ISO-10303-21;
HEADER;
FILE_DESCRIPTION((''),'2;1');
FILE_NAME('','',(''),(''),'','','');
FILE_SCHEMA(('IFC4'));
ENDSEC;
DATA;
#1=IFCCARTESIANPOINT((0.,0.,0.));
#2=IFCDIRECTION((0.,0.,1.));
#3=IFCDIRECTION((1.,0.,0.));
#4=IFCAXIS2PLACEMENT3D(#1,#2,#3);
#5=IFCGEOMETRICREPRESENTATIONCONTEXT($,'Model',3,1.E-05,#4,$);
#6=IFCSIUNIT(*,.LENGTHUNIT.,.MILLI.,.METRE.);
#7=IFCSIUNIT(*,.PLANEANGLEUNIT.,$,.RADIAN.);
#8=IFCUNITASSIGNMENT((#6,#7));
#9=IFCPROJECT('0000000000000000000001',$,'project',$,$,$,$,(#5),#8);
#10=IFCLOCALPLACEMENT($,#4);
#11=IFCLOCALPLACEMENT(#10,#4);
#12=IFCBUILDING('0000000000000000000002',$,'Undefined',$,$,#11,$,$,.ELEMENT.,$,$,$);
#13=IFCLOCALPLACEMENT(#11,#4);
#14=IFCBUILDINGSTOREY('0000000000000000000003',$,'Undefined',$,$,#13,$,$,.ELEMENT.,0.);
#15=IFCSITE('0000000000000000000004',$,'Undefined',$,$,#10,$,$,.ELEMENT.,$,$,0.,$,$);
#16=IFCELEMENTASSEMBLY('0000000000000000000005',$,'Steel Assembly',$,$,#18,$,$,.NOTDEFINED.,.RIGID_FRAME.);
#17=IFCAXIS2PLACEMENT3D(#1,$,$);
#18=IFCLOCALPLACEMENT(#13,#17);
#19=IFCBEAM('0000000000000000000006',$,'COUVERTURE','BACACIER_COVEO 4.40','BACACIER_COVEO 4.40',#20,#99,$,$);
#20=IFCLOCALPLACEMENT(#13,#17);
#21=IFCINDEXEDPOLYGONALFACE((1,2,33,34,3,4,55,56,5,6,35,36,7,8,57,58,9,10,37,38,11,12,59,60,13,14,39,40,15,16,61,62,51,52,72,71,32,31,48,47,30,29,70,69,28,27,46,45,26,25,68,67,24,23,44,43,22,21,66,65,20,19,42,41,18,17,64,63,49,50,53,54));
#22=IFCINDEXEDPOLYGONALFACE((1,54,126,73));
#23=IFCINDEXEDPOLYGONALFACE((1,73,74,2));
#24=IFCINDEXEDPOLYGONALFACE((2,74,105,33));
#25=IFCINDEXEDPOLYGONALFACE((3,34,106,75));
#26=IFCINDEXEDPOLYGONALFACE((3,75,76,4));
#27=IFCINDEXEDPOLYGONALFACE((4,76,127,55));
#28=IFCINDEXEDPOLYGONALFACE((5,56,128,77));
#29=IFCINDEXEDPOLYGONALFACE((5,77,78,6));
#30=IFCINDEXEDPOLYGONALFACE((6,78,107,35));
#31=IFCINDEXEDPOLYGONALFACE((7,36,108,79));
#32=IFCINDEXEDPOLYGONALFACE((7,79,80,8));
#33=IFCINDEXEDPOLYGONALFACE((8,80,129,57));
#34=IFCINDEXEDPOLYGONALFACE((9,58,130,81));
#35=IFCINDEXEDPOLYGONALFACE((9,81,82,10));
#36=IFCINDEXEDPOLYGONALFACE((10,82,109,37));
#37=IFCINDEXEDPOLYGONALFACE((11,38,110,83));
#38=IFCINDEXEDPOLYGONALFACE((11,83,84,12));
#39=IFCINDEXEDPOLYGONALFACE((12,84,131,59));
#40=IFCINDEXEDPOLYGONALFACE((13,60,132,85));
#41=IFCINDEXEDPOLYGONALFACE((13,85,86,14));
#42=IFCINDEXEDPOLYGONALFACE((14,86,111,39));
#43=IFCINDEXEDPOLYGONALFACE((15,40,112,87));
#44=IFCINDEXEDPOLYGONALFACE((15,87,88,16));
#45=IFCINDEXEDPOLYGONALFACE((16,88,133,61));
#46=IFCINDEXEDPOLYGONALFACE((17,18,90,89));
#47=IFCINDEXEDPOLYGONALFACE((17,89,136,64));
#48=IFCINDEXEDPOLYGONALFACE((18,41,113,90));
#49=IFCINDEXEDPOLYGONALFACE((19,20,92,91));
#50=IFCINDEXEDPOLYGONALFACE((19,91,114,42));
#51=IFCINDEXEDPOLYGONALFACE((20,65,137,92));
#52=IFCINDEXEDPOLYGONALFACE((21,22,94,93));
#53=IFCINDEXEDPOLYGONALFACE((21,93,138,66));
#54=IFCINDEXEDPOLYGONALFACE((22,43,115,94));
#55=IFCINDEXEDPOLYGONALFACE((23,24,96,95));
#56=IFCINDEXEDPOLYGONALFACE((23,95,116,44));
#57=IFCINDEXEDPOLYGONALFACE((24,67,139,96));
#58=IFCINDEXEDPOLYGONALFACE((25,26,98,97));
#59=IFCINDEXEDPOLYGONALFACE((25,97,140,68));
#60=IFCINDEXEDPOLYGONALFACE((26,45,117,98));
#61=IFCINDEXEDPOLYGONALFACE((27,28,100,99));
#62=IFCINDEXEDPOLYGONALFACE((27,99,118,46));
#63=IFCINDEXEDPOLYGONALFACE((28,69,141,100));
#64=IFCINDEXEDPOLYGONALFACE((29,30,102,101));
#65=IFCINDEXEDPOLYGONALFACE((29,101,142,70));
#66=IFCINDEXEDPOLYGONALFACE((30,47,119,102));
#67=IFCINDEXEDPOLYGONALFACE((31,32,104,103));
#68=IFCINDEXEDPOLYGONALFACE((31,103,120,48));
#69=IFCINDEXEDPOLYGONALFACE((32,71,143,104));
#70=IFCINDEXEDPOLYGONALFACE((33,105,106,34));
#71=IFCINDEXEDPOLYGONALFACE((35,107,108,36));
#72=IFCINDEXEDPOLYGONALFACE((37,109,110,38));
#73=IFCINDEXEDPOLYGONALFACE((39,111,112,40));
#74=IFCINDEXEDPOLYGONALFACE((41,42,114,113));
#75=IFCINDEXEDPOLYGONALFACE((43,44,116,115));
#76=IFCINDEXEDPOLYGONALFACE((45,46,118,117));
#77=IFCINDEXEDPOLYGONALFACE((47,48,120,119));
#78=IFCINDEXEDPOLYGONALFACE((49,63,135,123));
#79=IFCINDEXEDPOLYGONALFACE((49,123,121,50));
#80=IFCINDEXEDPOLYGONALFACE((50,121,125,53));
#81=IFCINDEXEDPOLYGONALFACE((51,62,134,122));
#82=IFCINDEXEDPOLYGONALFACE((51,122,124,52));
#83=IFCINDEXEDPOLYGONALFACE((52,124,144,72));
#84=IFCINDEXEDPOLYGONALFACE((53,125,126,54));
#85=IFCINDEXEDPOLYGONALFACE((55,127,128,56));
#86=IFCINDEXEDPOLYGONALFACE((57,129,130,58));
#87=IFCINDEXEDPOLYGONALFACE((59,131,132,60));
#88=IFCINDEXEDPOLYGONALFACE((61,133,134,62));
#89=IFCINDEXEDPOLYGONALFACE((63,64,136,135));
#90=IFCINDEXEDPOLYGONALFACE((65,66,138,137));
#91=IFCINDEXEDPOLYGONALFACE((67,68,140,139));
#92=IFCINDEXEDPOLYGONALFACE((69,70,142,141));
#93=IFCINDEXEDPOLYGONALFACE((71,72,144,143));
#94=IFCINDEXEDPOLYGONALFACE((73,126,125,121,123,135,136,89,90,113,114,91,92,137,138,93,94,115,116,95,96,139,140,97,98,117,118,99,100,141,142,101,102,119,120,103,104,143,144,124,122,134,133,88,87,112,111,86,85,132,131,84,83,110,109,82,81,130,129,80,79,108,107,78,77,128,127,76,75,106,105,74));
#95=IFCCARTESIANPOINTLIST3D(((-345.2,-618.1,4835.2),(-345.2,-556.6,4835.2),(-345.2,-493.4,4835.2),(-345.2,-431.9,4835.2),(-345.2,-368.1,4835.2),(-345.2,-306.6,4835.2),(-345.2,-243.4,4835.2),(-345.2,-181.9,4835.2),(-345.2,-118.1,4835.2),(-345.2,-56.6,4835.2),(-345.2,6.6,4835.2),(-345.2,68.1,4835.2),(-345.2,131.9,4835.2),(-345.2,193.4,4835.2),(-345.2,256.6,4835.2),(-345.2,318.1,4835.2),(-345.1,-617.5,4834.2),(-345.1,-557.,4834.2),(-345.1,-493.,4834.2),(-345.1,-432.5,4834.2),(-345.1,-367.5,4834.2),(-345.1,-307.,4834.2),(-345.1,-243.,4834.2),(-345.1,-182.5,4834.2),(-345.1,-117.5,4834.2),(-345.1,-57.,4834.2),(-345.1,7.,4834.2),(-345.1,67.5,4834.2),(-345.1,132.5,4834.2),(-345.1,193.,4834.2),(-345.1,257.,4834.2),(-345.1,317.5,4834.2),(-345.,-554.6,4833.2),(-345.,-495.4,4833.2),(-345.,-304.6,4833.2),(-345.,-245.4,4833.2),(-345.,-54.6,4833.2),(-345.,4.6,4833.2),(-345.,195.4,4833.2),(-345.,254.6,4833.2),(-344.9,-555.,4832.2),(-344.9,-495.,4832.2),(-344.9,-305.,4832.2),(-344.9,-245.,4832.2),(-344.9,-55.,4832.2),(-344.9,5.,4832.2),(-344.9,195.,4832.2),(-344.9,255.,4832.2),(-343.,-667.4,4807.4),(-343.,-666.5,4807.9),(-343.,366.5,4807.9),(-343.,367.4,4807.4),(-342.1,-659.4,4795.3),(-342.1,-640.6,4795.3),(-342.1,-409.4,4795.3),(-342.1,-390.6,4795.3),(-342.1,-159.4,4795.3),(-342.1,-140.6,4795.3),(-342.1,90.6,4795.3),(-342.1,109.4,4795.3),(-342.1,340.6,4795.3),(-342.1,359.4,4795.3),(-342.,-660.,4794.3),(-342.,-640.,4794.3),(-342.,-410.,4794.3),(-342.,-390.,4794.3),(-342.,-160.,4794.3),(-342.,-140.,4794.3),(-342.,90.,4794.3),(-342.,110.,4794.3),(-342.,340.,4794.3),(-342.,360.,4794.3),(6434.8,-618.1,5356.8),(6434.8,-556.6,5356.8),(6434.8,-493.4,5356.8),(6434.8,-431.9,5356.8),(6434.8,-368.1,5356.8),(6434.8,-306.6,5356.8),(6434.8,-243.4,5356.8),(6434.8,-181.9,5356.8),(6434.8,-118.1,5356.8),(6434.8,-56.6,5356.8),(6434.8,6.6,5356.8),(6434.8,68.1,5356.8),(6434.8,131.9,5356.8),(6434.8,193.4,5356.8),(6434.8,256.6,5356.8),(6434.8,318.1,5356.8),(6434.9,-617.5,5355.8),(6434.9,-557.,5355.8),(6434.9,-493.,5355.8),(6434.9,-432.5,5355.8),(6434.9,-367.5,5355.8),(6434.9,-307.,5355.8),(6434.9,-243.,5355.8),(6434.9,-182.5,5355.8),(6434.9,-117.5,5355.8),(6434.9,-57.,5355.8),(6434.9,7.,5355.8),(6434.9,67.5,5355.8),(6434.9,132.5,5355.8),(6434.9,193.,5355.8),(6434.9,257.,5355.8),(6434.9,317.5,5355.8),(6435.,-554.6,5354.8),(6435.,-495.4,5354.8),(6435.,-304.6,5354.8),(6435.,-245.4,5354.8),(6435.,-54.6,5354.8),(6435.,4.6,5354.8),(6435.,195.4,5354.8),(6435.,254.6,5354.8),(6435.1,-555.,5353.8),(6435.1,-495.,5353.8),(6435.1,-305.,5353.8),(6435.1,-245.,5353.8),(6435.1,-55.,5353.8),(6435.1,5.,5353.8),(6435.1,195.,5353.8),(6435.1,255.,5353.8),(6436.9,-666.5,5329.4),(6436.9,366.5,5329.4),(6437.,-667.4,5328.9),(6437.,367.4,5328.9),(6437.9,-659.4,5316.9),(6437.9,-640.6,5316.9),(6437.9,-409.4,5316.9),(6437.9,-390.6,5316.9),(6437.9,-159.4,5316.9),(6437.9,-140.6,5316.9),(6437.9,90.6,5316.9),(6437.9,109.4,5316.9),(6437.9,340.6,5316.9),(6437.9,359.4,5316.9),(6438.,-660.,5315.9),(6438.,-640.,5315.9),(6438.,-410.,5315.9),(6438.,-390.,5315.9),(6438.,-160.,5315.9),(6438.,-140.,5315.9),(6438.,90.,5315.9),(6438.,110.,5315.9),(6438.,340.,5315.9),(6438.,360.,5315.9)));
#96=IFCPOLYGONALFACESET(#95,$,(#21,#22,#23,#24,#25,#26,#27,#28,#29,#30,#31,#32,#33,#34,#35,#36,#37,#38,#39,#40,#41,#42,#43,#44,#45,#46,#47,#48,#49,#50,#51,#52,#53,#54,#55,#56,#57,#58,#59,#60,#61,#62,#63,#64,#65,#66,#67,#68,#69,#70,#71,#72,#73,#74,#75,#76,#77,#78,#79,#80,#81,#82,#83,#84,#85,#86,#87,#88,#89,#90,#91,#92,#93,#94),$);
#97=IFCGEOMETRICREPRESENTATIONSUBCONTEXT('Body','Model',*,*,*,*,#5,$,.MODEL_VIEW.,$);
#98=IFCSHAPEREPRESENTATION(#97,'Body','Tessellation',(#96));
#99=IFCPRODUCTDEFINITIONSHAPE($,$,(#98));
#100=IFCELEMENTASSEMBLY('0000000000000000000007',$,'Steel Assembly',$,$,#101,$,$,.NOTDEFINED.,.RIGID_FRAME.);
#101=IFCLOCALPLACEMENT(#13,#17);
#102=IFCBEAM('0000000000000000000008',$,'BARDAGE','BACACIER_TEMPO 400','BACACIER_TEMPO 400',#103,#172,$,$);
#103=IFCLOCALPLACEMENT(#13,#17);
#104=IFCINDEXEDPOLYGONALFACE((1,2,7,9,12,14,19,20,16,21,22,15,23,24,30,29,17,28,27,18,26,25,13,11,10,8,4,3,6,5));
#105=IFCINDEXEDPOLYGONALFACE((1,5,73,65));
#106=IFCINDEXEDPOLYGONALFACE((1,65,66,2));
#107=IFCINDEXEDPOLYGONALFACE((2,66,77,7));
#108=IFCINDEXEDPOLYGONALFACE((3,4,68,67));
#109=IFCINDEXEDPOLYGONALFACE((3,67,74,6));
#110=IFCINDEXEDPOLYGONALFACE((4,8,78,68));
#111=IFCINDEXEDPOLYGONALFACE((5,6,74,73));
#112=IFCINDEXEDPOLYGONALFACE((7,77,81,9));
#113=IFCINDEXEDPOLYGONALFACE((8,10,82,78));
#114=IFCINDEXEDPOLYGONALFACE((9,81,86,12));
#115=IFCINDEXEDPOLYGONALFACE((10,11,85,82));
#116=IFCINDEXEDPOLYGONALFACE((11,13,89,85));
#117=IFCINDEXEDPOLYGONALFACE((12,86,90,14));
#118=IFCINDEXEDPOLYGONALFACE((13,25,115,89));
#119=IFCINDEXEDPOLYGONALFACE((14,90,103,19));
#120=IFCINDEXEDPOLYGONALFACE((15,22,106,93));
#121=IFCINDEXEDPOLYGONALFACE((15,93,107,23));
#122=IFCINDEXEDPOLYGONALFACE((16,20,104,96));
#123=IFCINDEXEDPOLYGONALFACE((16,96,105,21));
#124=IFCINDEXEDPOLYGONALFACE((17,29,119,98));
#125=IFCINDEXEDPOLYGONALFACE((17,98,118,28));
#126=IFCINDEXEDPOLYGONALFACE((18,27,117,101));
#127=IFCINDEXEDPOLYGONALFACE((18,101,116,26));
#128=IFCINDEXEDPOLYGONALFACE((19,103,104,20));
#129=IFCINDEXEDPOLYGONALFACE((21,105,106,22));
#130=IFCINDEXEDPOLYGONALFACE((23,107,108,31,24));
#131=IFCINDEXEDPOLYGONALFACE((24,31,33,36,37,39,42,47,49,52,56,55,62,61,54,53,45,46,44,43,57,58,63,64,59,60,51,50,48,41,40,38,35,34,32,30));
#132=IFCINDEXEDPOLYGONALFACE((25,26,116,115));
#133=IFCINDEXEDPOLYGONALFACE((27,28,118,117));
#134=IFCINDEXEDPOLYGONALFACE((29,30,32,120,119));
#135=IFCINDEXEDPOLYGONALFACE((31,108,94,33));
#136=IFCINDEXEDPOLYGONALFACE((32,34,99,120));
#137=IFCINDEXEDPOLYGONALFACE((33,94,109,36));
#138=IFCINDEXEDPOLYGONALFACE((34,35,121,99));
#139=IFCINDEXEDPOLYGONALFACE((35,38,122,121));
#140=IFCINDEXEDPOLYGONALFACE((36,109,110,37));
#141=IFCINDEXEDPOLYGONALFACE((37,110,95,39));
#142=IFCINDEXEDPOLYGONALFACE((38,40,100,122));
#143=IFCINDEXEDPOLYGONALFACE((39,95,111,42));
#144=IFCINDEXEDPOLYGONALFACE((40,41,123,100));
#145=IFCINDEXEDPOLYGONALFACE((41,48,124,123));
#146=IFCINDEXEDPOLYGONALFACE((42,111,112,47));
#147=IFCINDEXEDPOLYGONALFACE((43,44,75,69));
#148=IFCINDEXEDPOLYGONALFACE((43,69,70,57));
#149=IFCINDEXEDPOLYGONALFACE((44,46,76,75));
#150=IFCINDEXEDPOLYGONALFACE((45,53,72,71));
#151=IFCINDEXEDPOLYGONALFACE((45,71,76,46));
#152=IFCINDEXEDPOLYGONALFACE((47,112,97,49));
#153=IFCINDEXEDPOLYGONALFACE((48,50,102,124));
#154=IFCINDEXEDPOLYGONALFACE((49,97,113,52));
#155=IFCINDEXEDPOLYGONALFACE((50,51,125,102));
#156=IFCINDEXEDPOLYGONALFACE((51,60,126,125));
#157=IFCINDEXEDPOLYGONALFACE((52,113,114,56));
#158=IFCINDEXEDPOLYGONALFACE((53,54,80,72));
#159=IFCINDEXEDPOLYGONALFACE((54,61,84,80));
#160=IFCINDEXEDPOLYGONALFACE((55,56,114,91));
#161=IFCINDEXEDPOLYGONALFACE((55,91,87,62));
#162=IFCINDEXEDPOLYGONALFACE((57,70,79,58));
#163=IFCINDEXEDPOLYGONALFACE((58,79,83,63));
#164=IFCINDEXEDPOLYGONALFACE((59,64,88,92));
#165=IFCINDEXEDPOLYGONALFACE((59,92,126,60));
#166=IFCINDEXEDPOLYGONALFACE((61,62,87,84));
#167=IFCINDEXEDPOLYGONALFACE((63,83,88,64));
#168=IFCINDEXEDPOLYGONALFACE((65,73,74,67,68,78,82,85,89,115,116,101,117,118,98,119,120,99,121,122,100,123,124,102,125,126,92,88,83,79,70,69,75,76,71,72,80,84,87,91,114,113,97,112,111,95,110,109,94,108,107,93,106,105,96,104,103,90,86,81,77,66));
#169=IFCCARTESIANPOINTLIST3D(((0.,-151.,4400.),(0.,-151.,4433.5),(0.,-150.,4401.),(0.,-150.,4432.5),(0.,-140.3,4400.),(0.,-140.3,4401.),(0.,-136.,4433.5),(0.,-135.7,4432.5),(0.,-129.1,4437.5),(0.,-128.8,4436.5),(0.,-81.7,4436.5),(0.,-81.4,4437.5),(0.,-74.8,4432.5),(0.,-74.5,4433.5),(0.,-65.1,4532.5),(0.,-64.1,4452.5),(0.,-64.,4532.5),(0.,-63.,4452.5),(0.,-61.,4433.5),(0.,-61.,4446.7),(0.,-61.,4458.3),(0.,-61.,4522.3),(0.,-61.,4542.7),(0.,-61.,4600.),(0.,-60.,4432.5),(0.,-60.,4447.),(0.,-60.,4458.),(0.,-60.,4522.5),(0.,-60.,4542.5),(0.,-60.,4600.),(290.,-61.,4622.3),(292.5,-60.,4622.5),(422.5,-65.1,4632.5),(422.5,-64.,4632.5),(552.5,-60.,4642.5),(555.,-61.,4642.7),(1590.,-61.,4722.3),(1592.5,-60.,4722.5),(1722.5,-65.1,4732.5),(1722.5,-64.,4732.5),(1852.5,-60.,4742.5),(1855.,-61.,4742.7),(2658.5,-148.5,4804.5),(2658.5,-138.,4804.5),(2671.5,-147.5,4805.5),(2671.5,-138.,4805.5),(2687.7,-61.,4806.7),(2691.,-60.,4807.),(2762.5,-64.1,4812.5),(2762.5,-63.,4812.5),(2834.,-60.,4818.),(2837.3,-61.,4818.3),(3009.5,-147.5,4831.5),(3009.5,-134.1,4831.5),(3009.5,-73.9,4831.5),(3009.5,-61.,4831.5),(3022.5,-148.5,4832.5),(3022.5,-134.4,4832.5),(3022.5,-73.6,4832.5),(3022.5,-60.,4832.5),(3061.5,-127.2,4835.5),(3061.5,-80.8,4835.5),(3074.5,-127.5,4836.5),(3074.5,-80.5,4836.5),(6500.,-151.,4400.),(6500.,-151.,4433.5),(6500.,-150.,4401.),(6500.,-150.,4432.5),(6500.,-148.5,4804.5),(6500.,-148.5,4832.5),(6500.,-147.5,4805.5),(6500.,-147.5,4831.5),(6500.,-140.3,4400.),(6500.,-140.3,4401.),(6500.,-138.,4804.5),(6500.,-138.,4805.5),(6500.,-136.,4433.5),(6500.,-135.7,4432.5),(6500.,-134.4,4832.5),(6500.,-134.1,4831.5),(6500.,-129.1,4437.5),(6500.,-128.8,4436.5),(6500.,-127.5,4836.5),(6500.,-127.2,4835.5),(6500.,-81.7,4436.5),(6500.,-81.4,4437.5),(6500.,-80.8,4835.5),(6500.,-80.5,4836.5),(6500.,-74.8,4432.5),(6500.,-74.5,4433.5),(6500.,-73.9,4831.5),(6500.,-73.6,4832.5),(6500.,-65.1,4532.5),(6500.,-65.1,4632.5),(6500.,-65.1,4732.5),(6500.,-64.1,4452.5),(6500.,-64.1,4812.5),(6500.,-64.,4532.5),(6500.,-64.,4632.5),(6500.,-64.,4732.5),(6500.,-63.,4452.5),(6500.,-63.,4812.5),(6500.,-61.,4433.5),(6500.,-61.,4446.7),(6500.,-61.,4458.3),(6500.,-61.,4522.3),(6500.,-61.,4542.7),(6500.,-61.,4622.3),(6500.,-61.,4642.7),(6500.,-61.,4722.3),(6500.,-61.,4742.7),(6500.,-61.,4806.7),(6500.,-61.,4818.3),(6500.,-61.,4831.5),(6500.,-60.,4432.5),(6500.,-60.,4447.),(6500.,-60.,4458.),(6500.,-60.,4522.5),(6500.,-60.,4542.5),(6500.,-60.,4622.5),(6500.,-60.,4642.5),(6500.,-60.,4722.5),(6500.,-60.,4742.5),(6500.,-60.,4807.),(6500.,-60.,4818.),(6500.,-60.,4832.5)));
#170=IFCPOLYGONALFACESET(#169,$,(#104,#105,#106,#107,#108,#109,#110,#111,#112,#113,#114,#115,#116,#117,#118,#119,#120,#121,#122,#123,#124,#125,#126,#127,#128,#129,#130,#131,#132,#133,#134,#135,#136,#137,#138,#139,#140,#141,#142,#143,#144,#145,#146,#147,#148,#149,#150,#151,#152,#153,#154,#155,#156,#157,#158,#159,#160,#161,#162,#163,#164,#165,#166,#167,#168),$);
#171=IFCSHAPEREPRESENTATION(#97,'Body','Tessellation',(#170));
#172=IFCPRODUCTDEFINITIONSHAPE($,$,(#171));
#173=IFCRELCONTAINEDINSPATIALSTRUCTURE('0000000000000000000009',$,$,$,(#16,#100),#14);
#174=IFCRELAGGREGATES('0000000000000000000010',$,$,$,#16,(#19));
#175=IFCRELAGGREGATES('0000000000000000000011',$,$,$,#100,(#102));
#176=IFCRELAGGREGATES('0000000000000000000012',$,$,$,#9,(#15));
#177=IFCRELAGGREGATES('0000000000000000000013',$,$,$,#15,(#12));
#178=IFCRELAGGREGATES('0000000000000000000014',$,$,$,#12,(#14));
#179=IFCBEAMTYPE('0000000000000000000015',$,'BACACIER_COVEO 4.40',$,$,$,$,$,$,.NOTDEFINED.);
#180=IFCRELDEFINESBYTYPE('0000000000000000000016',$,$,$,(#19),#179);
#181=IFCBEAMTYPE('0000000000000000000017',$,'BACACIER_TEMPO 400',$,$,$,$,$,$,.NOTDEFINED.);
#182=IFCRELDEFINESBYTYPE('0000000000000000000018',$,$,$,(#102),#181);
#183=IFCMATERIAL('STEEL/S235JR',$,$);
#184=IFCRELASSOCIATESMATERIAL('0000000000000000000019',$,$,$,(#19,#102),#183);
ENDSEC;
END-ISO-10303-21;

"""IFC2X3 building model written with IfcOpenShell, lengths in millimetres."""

from ifc_helpers import new_model, si_unit, frame, origin_with_axes, place, context, subcontext, project, spatial, polyline, outline, extrude, clip, halfspace, material, type_object, element, aggregate, save


model = new_model("IFC2X3")

# Units and contexts
model_context = context("Model", 3, precision=1e-05, world=origin_with_axes())
body_context = subcontext(model_context, "Body", "Model", "MODEL_VIEW")
ifc_project = project(units=[si_unit("LENGTHUNIT", "METRE", prefix="MILLI"), si_unit("PLANEANGLEUNIT", "RADIAN")], contexts=[model_context])

# Site, building, storey
site_placement = place(None, origin_with_axes())
site = spatial("IfcSite", under=ifc_project, at=site_placement, Name="Undefined", CompositionType="ELEMENT", RefElevation=0.0)
building_placement = place(site_placement, origin_with_axes())
building = spatial("IfcBuilding", under=site, at=building_placement, Name="Undefined", CompositionType="ELEMENT")
storey_placement = place(building_placement, origin_with_axes())
storey = spatial("IfcBuildingStorey", under=building, at=storey_placement, Name="Undefined", CompositionType="ELEMENT", Elevation=0.0)

# Element assemblies, beams
assembly_1_placement = place(storey_placement, origin_with_axes())
assembly_1 = element("IfcElementAssembly", 1, at=assembly_1_placement, inside=storey, Name="Steel Assembly", AssemblyPlace="NOTDEFINED", PredefinedType="RIGID_FRAME")
ifc_material_1 = material(Name="STEEL/S235JR")
beam_type_1 = type_object("IfcBeamType", Name="BACACIER_COVEO 4.40", PredefinedType="NOTDEFINED")
beam_1_placement = place(assembly_1_placement, frame((6436.4, -150.0, 5336.3), z_axis=(0.076696, 0.0, -0.997054), x_axis=(-0.997054, 0.0, -0.076696)))
beam_1 = element("IfcBeam", 2, at=beam_1_placement, type_object=beam_type_1, material=ifc_material_1, Name="COUVERTURE", Description="BACACIER_COVEO 4.40", ObjectType="BACACIER_COVEO 4.40", context=body_context, shape_type="SweptSolid", body=[
    extrude(outline(polyline([(509.4, 19.5), (490.6, 19.5), (468.1, -20.5), (406.6, -20.5), (404.6, -18.5), (345.4, -18.5), (343.4, -20.5), (281.9, -20.5), (259.4, 19.5), (240.6, 19.5), (218.1, -20.5), (156.6, -20.5), (154.6, -18.5), (95.4, -18.5), (93.4, -20.5), (31.9, -20.5), (9.4, 19.5), (-9.4, 19.5), (-31.9, -20.5), (-93.4, -20.5), (-95.4, -18.5), (-154.6, -18.5), (-156.6, -20.5), (-218.1, -20.5), (-240.6, 19.5), (-259.4, 19.5), (-281.9, -20.5), (-343.4, -20.5), (-345.4, -18.5), (-404.6, -18.5), (-406.6, -20.5), (-468.1, -20.5), (-490.6, 19.5), (-509.4, 19.5), (-516.5, 6.9), (-517.4, 7.4), (-510.0, 20.5), (-490.0, 20.5), (-467.5, -19.5), (-407.0, -19.5), (-405.0, -17.5), (-345.0, -17.5), (-343.0, -19.5), (-282.5, -19.5), (-260.0, 20.5), (-240.0, 20.5), (-217.5, -19.5), (-157.0, -19.5), (-155.0, -17.5), (-95.0, -17.5), (-93.0, -19.5), (-32.5, -19.5), (-10.0, 20.5), (10.0, 20.5), (32.5, -19.5), (93.0, -19.5), (95.0, -17.5), (155.0, -17.5), (157.0, -19.5), (217.5, -19.5), (240.0, 20.5), (260.0, 20.5), (282.5, -19.5), (343.0, -19.5), (345.0, -17.5), (405.0, -17.5), (407.0, -19.5), (467.5, -19.5), (490.0, 20.5), (510.0, 20.5), (517.4, 7.4), (516.5, 6.9), (509.4, 19.5)])), frame((6800.0, 0.0, 0.0), z_axis=(-1.0, 0.0, 0.0), x_axis=(0.0, -1.0, 0.0)), (0.0, 0.0, 1.0), 6800.0),
])
aggregate(assembly_1, [beam_1])
beam_type_2 = type_object("IfcBeamType", Name="BACACIER_TEMPO 400", PredefinedType="NOTDEFINED")
assembly_2_placement = place(storey_placement, origin_with_axes())
assembly_2 = element("IfcElementAssembly", 3, at=assembly_2_placement, inside=storey, Name="Steel Assembly", AssemblyPlace="NOTDEFINED", PredefinedType="RIGID_FRAME")
beam_2_placement = place(assembly_2_placement, frame((6500.0, -105.5, 4618.2), z_axis=(0.0, -1.0, 0.0), x_axis=(-1.0, 0.0, 0.0)))
beam_2 = element("IfcBeam", 4, at=beam_2_placement, type_object=beam_type_2, material=ifc_material_1, Name="BARDAGE", Description="BACACIER_TEMPO 400", ObjectType="BACACIER_TEMPO 400", context=body_context, shape_type="Clipping", body=[
    clip(extrude(outline(polyline([(218.2, -25.0), (214.2, -31.9), (214.2, -45.5), (199.8, -45.5), (194.2, -42.5), (188.8, -45.5), (124.2, -45.5), (114.2, -41.5), (104.2, -45.5), (24.2, -45.5), (14.2, -41.5), (4.2, -45.5), (-75.8, -45.5), (-85.8, -41.5), (-95.8, -45.5), (-160.2, -45.5), (-165.8, -42.5), (-171.2, -45.5), (-185.8, -45.5), (-185.8, -30.7), (-181.8, -23.8), (-181.8, 23.3), (-185.8, 30.2), (-185.8, 44.5), (-217.2, 44.5), (-217.2, 34.8), (-218.2, 34.8), (-218.2, 45.5), (-184.8, 45.5), (-184.8, 30.5), (-180.8, 23.6), (-180.8, -24.1), (-184.8, -31.0), (-184.8, -44.5), (-171.5, -44.5), (-165.8, -41.4), (-160.0, -44.5), (-95.9, -44.5), (-85.8, -40.4), (-75.6, -44.5), (4.1, -44.5), (14.2, -40.4), (24.4, -44.5), (104.1, -44.5), (114.2, -40.4), (124.4, -44.5), (188.5, -44.5), (194.2, -41.4), (200.0, -44.5), (213.2, -44.5), (213.2, -31.6), (217.2, -24.7), (217.2, 21.7), (213.2, 28.6), (213.2, 42.0), (187.2, 42.0), (187.2, 32.5), (186.2, 32.5), (186.2, 43.0), (214.2, 43.0), (214.2, 28.9), (218.2, 22.0), (218.2, -25.0)])), frame((6500.0, 0.0, 0.0), z_axis=(-1.0, 0.0, 0.0), x_axis=(0.0, -1.0, 0.0)), (0.0, 0.0, 1.0), 6500.0), halfspace(frame((6500.0, 18.3, -45.0), z_axis=(0.076696, -0.997054, 0.0), x_axis=(-0.997054, -0.076696, 0.0)), False)),
])
aggregate(assembly_2, [beam_2])

save(model, "model.ifc")
